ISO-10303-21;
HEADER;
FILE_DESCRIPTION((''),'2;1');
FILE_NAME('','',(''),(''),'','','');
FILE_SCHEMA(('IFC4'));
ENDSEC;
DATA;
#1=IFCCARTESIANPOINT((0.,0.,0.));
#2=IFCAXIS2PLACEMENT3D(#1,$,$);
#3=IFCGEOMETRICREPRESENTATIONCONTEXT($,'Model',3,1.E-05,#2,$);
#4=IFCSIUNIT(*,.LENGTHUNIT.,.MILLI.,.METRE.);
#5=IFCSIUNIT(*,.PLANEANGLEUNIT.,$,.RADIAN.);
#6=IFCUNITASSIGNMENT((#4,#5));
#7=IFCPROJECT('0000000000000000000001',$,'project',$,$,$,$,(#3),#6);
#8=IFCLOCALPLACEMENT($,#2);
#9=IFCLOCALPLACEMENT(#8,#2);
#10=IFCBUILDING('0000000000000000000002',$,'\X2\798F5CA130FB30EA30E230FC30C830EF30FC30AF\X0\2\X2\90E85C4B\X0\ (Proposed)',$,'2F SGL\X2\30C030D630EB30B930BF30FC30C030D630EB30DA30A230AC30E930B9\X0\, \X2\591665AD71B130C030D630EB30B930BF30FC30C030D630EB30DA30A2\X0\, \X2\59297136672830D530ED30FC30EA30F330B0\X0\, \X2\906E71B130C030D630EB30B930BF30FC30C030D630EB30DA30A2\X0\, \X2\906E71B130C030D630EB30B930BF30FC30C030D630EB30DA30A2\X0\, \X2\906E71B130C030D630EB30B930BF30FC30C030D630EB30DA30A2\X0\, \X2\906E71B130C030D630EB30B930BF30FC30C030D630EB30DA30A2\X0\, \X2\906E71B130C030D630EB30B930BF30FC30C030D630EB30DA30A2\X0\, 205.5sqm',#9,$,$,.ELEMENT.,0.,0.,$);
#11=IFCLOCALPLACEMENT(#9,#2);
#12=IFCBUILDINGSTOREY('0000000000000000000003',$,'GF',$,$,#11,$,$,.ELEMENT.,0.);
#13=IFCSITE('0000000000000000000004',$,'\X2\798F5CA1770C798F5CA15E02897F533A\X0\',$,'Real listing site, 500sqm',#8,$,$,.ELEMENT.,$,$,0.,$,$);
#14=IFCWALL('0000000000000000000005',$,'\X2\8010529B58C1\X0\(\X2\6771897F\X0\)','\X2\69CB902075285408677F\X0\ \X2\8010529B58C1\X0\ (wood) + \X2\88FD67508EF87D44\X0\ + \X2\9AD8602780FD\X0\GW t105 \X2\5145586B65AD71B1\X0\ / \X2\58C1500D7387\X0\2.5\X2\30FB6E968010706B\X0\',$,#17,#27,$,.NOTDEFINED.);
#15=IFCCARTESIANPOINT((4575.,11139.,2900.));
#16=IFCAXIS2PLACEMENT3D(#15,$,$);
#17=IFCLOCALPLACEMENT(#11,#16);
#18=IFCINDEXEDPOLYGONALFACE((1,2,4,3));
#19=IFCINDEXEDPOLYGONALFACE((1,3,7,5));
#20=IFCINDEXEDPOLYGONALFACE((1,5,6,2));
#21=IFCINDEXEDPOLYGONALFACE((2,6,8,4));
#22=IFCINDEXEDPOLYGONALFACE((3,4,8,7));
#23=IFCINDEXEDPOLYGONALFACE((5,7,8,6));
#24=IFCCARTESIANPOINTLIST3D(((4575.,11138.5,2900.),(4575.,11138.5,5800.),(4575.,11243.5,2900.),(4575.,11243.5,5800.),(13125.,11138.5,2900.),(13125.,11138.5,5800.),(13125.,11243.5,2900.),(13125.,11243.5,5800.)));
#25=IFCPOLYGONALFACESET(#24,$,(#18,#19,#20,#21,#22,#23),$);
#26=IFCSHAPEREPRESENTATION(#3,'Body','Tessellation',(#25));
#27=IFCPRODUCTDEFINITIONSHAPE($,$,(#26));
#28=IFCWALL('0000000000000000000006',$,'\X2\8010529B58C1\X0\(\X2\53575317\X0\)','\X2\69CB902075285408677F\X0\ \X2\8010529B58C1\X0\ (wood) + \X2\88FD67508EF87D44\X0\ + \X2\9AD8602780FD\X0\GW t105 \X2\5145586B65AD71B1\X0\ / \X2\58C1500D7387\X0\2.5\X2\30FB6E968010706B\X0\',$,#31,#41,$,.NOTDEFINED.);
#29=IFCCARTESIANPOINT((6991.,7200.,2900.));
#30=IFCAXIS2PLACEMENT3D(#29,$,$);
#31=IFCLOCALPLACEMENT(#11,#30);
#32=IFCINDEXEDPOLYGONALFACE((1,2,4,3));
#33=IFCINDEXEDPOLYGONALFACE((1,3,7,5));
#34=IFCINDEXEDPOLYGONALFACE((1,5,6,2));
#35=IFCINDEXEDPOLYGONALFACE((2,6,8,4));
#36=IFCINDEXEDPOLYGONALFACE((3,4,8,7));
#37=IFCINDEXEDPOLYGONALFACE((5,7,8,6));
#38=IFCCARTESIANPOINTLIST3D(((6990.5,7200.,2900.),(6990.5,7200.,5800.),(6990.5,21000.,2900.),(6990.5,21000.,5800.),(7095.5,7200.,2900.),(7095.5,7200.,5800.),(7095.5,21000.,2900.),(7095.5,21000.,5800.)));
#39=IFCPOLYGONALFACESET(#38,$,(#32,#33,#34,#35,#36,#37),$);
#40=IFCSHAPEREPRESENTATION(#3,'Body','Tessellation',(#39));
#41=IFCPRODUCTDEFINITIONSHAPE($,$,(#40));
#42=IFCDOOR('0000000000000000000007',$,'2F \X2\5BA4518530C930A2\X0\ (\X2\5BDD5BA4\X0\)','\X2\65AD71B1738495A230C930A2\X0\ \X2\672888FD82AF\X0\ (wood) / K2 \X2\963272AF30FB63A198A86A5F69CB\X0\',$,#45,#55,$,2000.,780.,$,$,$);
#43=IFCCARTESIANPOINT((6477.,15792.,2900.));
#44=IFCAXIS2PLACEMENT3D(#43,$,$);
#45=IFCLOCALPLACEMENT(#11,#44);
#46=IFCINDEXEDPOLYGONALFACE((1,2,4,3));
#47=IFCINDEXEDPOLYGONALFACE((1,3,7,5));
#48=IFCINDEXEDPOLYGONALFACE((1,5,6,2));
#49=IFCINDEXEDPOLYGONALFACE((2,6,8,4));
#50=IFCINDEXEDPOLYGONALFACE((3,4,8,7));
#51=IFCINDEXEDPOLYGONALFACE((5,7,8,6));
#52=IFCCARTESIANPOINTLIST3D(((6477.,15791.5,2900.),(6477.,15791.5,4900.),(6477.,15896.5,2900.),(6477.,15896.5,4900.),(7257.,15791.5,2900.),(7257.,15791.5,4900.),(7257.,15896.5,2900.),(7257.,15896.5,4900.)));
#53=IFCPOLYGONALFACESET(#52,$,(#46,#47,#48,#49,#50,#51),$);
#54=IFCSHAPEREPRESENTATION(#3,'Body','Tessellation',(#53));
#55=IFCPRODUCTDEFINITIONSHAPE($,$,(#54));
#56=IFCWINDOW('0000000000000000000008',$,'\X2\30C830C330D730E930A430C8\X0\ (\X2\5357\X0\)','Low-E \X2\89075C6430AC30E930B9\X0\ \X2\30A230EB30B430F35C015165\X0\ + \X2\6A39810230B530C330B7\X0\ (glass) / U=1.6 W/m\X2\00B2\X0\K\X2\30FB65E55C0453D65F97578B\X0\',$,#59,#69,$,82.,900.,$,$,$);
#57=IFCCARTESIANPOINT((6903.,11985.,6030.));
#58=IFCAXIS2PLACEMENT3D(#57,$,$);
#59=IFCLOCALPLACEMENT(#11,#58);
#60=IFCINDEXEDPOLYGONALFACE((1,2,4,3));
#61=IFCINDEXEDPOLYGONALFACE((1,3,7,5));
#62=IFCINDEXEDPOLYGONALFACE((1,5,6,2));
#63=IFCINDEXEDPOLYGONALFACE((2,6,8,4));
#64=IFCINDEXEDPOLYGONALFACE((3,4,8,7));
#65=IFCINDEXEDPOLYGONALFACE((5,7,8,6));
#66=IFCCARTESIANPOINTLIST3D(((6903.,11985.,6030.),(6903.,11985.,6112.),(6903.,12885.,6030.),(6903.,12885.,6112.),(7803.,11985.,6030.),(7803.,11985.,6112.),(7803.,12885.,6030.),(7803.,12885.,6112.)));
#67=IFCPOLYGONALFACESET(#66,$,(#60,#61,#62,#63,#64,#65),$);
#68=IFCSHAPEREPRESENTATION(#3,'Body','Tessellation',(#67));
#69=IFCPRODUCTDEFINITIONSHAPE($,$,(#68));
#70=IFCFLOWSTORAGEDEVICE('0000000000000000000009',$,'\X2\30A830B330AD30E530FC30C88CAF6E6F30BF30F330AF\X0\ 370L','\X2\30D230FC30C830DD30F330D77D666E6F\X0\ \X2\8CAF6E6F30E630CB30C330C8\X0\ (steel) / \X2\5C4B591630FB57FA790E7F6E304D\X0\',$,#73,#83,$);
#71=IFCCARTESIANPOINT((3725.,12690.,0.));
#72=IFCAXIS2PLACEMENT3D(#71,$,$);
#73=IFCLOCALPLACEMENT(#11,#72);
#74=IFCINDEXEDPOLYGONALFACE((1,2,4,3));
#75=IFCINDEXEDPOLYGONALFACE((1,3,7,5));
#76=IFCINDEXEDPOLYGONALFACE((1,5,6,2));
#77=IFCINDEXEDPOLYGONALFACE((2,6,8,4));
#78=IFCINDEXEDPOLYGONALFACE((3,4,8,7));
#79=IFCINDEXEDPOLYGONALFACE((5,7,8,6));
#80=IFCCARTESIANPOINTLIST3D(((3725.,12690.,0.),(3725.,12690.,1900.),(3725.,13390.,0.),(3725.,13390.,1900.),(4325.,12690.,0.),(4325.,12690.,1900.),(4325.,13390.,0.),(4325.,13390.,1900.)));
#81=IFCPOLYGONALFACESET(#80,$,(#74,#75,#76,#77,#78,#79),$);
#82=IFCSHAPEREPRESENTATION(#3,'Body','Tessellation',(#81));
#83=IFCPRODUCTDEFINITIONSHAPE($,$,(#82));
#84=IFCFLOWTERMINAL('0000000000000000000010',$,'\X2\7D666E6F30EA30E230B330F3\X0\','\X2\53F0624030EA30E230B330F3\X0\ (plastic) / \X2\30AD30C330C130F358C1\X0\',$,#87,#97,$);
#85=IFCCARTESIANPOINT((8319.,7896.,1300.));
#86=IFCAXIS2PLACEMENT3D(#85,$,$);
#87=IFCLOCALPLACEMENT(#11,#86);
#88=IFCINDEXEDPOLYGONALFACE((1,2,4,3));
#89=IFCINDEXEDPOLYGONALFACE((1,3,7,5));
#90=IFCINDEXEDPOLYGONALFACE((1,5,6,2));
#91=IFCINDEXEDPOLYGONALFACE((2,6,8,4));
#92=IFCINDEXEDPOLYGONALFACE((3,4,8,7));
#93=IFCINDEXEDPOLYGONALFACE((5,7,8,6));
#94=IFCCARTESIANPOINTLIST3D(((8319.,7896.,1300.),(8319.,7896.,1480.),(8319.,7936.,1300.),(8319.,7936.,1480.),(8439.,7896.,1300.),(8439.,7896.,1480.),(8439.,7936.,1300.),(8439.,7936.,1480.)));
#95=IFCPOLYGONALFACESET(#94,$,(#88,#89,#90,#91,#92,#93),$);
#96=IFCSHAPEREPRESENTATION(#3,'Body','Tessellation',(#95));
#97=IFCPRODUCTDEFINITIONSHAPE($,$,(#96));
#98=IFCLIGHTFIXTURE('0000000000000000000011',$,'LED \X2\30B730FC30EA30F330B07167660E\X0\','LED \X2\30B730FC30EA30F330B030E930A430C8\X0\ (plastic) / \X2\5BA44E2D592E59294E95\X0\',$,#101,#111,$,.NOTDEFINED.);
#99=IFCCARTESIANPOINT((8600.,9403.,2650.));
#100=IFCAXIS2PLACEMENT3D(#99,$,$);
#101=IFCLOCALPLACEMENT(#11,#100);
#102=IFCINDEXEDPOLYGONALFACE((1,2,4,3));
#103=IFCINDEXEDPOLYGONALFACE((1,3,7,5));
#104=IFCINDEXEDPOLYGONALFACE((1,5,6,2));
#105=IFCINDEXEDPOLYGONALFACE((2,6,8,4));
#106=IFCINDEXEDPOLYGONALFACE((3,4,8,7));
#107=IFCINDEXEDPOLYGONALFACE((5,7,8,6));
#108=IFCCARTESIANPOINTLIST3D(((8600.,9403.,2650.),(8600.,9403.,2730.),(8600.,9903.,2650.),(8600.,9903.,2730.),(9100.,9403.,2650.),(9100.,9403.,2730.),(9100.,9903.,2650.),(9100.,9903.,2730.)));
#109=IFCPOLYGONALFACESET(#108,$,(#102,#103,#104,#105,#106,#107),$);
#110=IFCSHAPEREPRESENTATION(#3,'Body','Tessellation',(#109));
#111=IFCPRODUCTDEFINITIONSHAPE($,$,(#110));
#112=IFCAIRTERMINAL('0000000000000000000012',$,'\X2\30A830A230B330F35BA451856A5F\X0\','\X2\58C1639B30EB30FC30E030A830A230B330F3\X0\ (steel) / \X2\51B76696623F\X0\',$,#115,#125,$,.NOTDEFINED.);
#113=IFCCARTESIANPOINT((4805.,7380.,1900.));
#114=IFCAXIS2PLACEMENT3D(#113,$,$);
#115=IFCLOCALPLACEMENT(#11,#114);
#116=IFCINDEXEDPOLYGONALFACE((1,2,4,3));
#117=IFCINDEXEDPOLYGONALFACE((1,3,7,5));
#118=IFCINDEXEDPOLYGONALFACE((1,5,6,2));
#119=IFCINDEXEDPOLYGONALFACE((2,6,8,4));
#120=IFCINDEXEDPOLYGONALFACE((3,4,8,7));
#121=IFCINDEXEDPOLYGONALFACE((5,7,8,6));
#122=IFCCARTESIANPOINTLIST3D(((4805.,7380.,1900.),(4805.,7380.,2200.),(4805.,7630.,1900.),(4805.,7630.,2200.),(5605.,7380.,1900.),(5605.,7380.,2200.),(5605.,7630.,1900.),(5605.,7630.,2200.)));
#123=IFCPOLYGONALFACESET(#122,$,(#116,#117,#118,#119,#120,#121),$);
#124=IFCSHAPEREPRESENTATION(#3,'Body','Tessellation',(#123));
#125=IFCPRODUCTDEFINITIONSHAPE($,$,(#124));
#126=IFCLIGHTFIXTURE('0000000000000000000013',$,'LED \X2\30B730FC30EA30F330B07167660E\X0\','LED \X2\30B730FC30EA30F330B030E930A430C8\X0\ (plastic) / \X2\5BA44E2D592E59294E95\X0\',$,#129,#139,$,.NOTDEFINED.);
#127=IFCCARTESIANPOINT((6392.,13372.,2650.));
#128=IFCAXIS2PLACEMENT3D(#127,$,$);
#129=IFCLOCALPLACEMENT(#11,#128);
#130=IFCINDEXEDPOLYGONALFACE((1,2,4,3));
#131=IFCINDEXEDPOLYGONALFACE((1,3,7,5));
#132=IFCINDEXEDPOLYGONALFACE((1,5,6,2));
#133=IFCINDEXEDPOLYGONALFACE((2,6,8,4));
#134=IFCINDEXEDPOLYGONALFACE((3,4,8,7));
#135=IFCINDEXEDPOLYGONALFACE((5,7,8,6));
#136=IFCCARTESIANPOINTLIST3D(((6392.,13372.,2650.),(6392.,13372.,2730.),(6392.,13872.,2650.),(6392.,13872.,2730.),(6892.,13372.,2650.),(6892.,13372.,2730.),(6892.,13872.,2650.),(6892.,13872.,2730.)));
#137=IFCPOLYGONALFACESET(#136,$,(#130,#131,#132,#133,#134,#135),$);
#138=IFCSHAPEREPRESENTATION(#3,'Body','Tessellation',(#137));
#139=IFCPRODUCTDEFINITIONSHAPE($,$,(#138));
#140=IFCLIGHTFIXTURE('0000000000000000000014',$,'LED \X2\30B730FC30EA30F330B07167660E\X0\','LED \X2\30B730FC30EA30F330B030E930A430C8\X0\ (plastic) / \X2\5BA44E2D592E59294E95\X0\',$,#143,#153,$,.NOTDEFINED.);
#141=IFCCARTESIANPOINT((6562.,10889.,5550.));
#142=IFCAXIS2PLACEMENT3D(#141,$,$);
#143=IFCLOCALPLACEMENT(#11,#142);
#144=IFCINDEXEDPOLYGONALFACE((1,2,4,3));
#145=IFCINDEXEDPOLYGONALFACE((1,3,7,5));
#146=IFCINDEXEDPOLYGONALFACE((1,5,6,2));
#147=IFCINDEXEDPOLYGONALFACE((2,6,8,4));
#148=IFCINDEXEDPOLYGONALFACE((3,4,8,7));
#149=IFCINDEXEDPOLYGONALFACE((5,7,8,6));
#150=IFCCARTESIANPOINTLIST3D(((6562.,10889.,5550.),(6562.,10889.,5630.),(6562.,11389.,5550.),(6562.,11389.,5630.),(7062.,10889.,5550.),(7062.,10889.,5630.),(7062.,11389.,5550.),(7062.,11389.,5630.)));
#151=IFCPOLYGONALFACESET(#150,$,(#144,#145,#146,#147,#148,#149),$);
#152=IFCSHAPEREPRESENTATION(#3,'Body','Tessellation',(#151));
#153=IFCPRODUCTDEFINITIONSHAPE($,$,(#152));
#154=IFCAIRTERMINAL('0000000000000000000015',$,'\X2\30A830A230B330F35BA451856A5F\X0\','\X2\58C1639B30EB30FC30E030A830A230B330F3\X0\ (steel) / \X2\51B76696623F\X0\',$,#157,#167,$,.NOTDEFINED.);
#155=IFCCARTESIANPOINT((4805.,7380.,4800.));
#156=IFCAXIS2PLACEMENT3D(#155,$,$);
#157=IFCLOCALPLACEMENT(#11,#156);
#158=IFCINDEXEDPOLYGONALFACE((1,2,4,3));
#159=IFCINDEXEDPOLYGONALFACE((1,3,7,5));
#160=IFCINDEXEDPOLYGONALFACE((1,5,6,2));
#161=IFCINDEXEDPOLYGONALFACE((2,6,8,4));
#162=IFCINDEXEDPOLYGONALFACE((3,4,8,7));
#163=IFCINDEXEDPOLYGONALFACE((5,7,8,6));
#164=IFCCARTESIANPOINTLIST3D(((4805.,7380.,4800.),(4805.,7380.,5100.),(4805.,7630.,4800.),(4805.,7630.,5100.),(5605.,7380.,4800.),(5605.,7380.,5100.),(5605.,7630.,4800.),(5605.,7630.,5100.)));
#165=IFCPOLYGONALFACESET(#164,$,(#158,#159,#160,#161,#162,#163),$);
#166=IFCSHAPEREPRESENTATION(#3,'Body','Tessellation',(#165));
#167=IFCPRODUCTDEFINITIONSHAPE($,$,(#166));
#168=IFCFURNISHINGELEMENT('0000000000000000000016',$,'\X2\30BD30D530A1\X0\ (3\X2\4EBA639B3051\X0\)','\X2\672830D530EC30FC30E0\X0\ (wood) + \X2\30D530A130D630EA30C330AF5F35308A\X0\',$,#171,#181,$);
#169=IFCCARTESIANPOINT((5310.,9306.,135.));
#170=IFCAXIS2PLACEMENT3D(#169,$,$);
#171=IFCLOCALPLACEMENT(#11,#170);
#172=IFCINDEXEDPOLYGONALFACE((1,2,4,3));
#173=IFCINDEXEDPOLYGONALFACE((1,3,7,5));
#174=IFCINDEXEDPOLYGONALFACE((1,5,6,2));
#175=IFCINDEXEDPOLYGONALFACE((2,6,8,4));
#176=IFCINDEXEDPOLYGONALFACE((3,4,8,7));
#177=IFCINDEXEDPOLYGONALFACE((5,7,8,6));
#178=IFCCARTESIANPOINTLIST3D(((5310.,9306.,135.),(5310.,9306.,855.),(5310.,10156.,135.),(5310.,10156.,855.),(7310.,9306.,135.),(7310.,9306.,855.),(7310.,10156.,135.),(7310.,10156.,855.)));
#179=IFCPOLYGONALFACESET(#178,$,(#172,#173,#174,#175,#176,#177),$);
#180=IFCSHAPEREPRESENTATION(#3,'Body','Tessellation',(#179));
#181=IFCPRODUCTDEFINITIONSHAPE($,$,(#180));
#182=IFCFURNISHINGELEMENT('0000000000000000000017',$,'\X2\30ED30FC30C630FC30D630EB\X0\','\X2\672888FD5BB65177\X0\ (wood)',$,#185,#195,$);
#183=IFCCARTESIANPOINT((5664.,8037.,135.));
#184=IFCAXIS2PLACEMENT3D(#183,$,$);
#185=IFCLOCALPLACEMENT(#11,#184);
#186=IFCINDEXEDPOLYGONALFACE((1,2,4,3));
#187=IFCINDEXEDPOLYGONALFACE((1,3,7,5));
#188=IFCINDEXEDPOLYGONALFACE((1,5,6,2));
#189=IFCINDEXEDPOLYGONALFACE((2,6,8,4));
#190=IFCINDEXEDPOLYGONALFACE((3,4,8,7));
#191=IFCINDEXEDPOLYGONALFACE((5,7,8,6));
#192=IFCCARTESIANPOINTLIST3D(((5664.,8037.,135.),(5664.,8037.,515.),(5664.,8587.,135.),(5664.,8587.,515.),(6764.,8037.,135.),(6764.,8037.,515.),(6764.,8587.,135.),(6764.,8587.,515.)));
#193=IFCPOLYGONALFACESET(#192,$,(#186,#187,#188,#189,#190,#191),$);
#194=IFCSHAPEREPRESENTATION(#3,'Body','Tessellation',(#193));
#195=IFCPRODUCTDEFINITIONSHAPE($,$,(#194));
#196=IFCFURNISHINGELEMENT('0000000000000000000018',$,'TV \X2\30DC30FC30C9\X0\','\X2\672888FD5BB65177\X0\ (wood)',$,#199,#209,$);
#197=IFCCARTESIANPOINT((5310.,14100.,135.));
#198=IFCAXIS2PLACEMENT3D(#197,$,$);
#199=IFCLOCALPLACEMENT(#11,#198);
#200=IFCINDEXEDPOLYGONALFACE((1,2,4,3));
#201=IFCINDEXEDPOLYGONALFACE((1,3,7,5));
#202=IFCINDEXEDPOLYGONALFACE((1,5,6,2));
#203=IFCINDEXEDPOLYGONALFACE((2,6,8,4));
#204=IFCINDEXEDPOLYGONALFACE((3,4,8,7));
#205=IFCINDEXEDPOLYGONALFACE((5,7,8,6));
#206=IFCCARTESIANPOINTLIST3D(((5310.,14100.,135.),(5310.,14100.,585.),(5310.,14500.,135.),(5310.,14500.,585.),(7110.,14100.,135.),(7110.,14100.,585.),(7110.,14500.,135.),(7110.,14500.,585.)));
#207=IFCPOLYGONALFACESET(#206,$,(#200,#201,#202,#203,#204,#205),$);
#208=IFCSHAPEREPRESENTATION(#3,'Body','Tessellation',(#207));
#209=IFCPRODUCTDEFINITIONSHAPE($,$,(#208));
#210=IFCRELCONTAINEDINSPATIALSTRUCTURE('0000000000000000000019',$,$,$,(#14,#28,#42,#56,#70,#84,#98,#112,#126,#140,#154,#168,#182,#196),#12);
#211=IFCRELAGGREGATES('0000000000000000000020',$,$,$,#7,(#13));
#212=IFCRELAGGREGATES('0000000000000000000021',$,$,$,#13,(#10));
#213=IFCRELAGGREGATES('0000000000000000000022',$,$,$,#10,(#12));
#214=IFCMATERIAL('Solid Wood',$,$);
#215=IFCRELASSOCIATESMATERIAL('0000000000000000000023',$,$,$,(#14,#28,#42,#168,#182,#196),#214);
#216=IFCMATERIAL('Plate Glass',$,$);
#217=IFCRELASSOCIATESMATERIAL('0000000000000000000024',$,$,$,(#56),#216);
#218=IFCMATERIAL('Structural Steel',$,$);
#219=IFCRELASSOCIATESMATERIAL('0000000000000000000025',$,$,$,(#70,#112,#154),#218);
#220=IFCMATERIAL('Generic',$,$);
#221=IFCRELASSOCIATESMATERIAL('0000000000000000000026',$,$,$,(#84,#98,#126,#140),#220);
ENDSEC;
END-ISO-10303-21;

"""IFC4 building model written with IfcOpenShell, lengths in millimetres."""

from ifc_helpers import new_model, si_unit, frame, frame_2d, origin, place, context, project, spatial, rectangle, extrude, material, element, fill, save


model = new_model("IFC4")

# Units and contexts
model_context = context("Model", 3, precision=1e-05, world=origin())
ifc_project = project(units=[si_unit("LENGTHUNIT", "METRE", prefix="MILLI"), si_unit("PLANEANGLEUNIT", "RADIAN")], contexts=[model_context])

# Site, building, storey
site_placement = place(None, origin())
site = spatial("IfcSite", under=ifc_project, at=site_placement, Name="福岡県福岡市西区", ObjectType="Real listing site, 500sqm", CompositionType="ELEMENT", RefElevation=0.0)
building_placement = place(site_placement, origin())
building = spatial("IfcBuilding", under=site, at=building_placement, Name="福岡・リモートワーク2部屋 (Proposed)", ObjectType="2F SGLダブルスターダブルペアガラス, 外断熱ダブルスターダブルペア, 天然木フローリング, 遮熱ダブルスターダブルペア, 遮熱ダブルスターダブルペア, 遮熱ダブルスターダブルペア, 遮熱ダブルスターダブルペア, 遮熱ダブルスターダブルペア, 205.5sqm", CompositionType="ELEMENT", ElevationOfRefHeight=0.0, ElevationOfTerrain=0.0)
storey_placement = place(building_placement, origin())
storey = spatial("IfcBuildingStorey", under=building, at=storey_placement, Name="GF", CompositionType="ELEMENT", Elevation=0.0)

# Shared definitions
ifc_material_1 = material(Name="Solid Wood")

# Wall
wall_1_placement = place(storey_placement, frame((4575.0, 11139.0, 2900.0)))
element("IfcWall", 1, at=wall_1_placement, inside=storey, material=ifc_material_1, Name="耐力壁(東西)", Description="構造用合板 耐力壁 (wood) + 製材軸組 + 高性能GW t105 充填断熱 / 壁倍率2.5・準耐火", PredefinedType="NOTDEFINED", context=model_context, shape_type="SweptSolid", body=[
    extrude(rectangle(XDim=8550.0, YDim=105.0, at=frame_2d((4275.0, 52.0))), frame((4575.0, 11139.0, 2900.0)), (0.0, 0.0, 1.0), 2900.0),
])

# Wall, opening, door
wall_2_placement = place(storey_placement, frame((6991.0, 7200.0, 2900.0)))
wall_2 = element("IfcWall", 2, at=wall_2_placement, inside=storey, material=ifc_material_1, Name="耐力壁(南北)", Description="構造用合板 耐力壁 (wood) + 製材軸組 + 高性能GW t105 充填断熱 / 壁倍率2.5・準耐火", PredefinedType="NOTDEFINED", context=model_context, shape_type="SweptSolid", body=[
    extrude(rectangle(XDim=105.0, YDim=13800.0, at=frame_2d((52.0, 6900.0))), frame((6991.0, 7200.0, 2900.0)), (0.0, 0.0, 1.0), 2900.0),
])
opening_placement = place(storey_placement, frame((6477.0, 15792.0, 2900.0)))
opening = element("IfcOpeningElement", 3, at=opening_placement, cuts=wall_2, PredefinedType="NOTDEFINED", context=model_context, shape_type="SweptSolid", body=[
    extrude(rectangle(XDim=780.0, YDim=105.0, at=frame_2d((390.0, 52.0))), frame((6477.0, 15792.0, 2900.0)), (0.0, 0.0, 1.0), 2000.0),
])
door_placement = place(storey_placement, frame((6477.0, 15792.0, 2900.0)))
door = element("IfcDoor", 4, at=door_placement, inside=storey, material=ifc_material_1, Name="2F 室内ドア (寝室)", Description="断熱玄関ドア 木製芯 (wood) / K2 防犯・採風機構", OverallHeight=2000.0, OverallWidth=780.0, context=model_context, shape_type="SweptSolid", body=[
    extrude(rectangle(XDim=780.0, YDim=105.0, at=frame_2d((390.0, 52.0))), frame((6477.0, 15792.0, 2900.0)), (0.0, 0.0, 1.0), 2000.0),
])
fill(opening, door)

# Window
ifc_material_2 = material(Name="Plate Glass")
window_placement = place(storey_placement, frame((6903.0, 11985.0, 6030.0)))
element("IfcWindow", 5, at=window_placement, inside=storey, material=ifc_material_2, Name="トップライト (南)", Description="Low-E 複層ガラス アルゴン封入 + 樹脂サッシ (glass) / U=1.6 W/m²K・日射取得型", OverallHeight=82.0, OverallWidth=900.0, context=model_context, shape_type="SweptSolid", body=[
    extrude(rectangle(XDim=900.0, YDim=900.0, at=frame_2d((450.0, 450.0))), frame((6903.0, 11985.0, 6030.0)), (0.0, 0.0, 1.0), 82.0),
])

# Flow storage device
ifc_material_3 = material(Name="Structural Steel")
flow_storage_device_placement = place(storey_placement, frame((3725.0, 12690.0, 0.0)))
element("IfcFlowStorageDevice", 6, at=flow_storage_device_placement, inside=storey, material=ifc_material_3, Name="エコキュート貯湯タンク 370L", Description="ヒートポンプ給湯 貯湯ユニット (steel) / 屋外・基礎置き", context=model_context, shape_type="SweptSolid", body=[
    extrude(rectangle(XDim=600.0, YDim=700.0, at=frame_2d((300.0, 350.0))), frame((3725.0, 12690.0, 0.0)), (0.0, 0.0, 1.0), 1900.0),
])

# Flow terminal
ifc_material_4 = material(Name="Generic")
flow_terminal_placement = place(storey_placement, frame((8319.0, 7896.0, 1300.0)))
element("IfcFlowTerminal", 7, at=flow_terminal_placement, inside=storey, material=ifc_material_4, Name="給湯リモコン", Description="台所リモコン (plastic) / キッチン壁", context=model_context, shape_type="SweptSolid", body=[
    extrude(rectangle(XDim=120.0, YDim=40.0, at=frame_2d((60.0, 20.0))), frame((8319.0, 7896.0, 1300.0)), (0.0, 0.0, 1.0), 180.0),
])

# Light fixture
light_fixture_1_placement = place(storey_placement, frame((8600.0, 9403.0, 2650.0)))
element("IfcLightFixture", 8, at=light_fixture_1_placement, inside=storey, material=ifc_material_4, Name="LED シーリング照明", Description="LED シーリングライト (plastic) / 室中央天井", PredefinedType="NOTDEFINED", context=model_context, shape_type="SweptSolid", body=[
    extrude(rectangle(XDim=500.0, YDim=500.0, at=frame_2d((250.0, 250.0))), frame((8600.0, 9403.0, 2650.0)), (0.0, 0.0, 1.0), 80.0),
])

# Air terminal
air_terminal_1_placement = place(storey_placement, frame((4805.0, 7380.0, 1900.0)))
element("IfcAirTerminal", 9, at=air_terminal_1_placement, inside=storey, material=ifc_material_3, Name="エアコン室内機", Description="壁掛ルームエアコン (steel) / 冷暖房", PredefinedType="NOTDEFINED", context=model_context, shape_type="SweptSolid", body=[
    extrude(rectangle(XDim=800.0, YDim=250.0, at=frame_2d((400.0, 125.0))), frame((4805.0, 7380.0, 1900.0)), (0.0, 0.0, 1.0), 300.0),
])

# Light fixtures
light_fixture_2_placement = place(storey_placement, frame((6392.0, 13372.0, 2650.0)))
element("IfcLightFixture", 10, at=light_fixture_2_placement, inside=storey, material=ifc_material_4, Name="LED シーリング照明", Description="LED シーリングライト (plastic) / 室中央天井", PredefinedType="NOTDEFINED", context=model_context, shape_type="SweptSolid", body=[
    extrude(rectangle(XDim=500.0, YDim=500.0, at=frame_2d((250.0, 250.0))), frame((6392.0, 13372.0, 2650.0)), (0.0, 0.0, 1.0), 80.0),
])
light_fixture_3_placement = place(storey_placement, frame((6562.0, 10889.0, 5550.0)))
element("IfcLightFixture", 11, at=light_fixture_3_placement, inside=storey, material=ifc_material_4, Name="LED シーリング照明", Description="LED シーリングライト (plastic) / 室中央天井", PredefinedType="NOTDEFINED", context=model_context, shape_type="SweptSolid", body=[
    extrude(rectangle(XDim=500.0, YDim=500.0, at=frame_2d((250.0, 250.0))), frame((6562.0, 10889.0, 5550.0)), (0.0, 0.0, 1.0), 80.0),
])

# Air terminal
air_terminal_2_placement = place(storey_placement, frame((4805.0, 7380.0, 4800.0)))
element("IfcAirTerminal", 12, at=air_terminal_2_placement, inside=storey, material=ifc_material_3, Name="エアコン室内機", Description="壁掛ルームエアコン (steel) / 冷暖房", PredefinedType="NOTDEFINED", context=model_context, shape_type="SweptSolid", body=[
    extrude(rectangle(XDim=800.0, YDim=250.0, at=frame_2d((400.0, 125.0))), frame((4805.0, 7380.0, 4800.0)), (0.0, 0.0, 1.0), 300.0),
])

# Furnishing elements
furnishing_1_placement = place(storey_placement, frame((5310.0, 9306.0, 135.0)))
element("IfcFurnishingElement", 13, at=furnishing_1_placement, inside=storey, material=ifc_material_1, Name="ソファ (3人掛け)", Description="木フレーム (wood) + ファブリック張り", context=model_context, shape_type="SweptSolid", body=[
    extrude(rectangle(XDim=2000.0, YDim=850.0, at=frame_2d((1000.0, 425.0))), frame((5310.0, 9306.0, 135.0)), (0.0, 0.0, 1.0), 720.0),
])
furnishing_2_placement = place(storey_placement, frame((5664.0, 8037.0, 135.0)))
element("IfcFurnishingElement", 14, at=furnishing_2_placement, inside=storey, material=ifc_material_1, Name="ローテーブル", Description="木製家具 (wood)", context=model_context, shape_type="SweptSolid", body=[
    extrude(rectangle(XDim=1100.0, YDim=550.0, at=frame_2d((550.0, 275.0))), frame((5664.0, 8037.0, 135.0)), (0.0, 0.0, 1.0), 380.0),
])
furnishing_3_placement = place(storey_placement, frame((5310.0, 14100.0, 135.0)))
element("IfcFurnishingElement", 15, at=furnishing_3_placement, inside=storey, material=ifc_material_1, Name="TV ボード", Description="木製家具 (wood)", context=model_context, shape_type="SweptSolid", body=[
    extrude(rectangle(XDim=1800.0, YDim=400.0, at=frame_2d((900.0, 200.0))), frame((5310.0, 14100.0, 135.0)), (0.0, 0.0, 1.0), 450.0),
])

save(model, "model.ifc")
